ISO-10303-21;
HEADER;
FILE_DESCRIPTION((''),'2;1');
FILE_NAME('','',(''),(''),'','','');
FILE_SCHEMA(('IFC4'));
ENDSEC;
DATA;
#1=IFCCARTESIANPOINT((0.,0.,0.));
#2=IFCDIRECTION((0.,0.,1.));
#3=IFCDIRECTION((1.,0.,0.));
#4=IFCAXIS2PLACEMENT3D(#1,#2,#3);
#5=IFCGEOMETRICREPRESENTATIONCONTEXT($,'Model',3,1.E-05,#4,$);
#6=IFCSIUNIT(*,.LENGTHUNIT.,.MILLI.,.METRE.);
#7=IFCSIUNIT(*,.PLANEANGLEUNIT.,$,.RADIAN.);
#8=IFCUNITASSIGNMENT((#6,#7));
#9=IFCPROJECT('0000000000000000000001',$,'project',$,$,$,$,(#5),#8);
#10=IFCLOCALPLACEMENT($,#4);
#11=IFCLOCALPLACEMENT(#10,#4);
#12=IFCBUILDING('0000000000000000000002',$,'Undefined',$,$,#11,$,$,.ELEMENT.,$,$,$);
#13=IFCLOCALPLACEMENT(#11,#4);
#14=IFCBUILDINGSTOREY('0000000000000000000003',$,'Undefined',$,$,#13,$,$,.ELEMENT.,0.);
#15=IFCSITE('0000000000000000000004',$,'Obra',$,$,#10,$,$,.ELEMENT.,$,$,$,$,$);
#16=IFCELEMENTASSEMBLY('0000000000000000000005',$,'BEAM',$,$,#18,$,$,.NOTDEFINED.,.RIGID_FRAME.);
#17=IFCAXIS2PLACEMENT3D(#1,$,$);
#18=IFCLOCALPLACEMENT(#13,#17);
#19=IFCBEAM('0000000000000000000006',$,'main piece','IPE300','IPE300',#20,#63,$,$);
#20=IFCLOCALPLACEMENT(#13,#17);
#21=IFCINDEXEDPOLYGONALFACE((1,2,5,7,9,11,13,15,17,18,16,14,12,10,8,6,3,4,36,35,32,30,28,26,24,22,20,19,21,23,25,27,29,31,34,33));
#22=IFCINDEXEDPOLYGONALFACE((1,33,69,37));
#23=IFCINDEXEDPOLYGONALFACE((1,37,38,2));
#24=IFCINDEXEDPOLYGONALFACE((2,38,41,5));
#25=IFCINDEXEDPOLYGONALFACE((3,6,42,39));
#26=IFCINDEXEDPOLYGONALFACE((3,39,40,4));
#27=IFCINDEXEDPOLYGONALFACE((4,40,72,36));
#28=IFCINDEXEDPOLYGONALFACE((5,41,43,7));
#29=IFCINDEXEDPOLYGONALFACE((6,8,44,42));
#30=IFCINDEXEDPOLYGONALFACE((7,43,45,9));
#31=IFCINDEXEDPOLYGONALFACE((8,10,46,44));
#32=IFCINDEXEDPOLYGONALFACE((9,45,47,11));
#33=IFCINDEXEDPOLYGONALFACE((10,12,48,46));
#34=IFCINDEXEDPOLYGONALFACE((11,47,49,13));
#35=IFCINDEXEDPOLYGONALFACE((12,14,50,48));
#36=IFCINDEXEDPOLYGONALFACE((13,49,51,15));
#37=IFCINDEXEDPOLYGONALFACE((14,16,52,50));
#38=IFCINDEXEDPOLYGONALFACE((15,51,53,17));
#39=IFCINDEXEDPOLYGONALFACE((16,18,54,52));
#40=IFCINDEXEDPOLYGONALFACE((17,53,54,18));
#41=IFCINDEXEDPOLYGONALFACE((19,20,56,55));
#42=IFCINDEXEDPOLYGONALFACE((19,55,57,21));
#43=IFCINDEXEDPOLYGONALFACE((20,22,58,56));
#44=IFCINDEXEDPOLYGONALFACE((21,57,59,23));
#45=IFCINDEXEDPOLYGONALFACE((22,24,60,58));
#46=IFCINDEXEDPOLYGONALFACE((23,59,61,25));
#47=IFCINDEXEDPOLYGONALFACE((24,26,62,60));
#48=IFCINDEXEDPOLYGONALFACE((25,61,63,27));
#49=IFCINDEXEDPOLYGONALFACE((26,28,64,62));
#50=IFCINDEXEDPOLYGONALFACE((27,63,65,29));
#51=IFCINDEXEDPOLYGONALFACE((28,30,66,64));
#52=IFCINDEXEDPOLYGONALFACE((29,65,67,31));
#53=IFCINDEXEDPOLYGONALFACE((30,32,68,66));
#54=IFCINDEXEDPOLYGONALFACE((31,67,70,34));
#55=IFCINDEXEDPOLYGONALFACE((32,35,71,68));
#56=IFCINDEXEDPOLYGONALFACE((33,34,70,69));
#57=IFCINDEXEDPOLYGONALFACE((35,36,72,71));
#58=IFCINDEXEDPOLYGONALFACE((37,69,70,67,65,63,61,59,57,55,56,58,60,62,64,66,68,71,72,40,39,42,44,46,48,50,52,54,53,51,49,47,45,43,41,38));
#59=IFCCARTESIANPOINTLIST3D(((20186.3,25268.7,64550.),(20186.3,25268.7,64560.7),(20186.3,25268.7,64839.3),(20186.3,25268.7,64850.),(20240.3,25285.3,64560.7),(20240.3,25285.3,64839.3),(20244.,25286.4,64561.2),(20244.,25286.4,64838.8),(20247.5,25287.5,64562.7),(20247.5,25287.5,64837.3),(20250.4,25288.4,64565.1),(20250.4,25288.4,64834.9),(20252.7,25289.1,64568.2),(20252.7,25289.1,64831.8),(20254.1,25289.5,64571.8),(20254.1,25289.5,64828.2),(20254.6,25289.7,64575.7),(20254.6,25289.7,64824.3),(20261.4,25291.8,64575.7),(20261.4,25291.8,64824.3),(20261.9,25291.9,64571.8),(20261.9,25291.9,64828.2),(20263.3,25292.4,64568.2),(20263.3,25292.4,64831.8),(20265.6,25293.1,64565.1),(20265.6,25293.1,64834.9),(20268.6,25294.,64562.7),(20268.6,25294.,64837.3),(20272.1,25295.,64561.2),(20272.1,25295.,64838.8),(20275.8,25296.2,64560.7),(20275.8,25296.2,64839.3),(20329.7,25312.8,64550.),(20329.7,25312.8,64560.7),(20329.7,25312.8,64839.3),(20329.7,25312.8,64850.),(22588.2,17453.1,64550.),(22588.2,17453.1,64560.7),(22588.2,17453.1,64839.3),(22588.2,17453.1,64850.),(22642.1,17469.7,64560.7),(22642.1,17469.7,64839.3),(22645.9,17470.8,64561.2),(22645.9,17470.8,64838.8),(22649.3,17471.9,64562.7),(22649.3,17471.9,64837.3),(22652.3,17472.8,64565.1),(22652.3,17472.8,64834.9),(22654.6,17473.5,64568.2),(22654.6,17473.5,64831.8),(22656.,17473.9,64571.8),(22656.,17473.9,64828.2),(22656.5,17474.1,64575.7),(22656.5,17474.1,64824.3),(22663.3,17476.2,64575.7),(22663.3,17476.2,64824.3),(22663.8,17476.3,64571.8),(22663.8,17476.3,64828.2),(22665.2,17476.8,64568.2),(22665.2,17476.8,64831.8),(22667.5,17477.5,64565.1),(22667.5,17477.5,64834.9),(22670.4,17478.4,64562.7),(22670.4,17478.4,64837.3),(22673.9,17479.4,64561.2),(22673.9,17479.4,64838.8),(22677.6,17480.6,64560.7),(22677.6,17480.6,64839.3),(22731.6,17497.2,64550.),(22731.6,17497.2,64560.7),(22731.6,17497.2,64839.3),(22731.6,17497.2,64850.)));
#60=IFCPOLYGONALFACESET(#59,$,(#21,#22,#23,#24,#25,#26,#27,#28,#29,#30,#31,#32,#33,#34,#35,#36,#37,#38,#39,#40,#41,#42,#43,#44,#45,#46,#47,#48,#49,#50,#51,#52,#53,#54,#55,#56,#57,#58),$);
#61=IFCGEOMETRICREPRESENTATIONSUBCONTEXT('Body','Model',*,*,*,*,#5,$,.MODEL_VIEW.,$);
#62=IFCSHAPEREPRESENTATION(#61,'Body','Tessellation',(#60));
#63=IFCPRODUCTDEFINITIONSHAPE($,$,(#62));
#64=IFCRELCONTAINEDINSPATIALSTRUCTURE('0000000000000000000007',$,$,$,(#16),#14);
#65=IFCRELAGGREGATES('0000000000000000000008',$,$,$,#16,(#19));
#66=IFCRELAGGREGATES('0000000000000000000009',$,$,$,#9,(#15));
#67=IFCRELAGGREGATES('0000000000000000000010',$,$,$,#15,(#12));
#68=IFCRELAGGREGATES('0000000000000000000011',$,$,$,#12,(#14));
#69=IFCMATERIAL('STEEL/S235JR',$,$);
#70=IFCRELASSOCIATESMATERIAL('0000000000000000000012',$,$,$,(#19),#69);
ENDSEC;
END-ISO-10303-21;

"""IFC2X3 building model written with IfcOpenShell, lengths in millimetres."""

from ifc_helpers import new_model, si_unit, frame, origin_with_axes, origin_2d_with_axis, place, context, subcontext, project, spatial, i_section, extrude, material, element, aggregate, save


model = new_model("IFC2X3")

# Units and contexts
model_context = context("Model", 3, precision=1e-05, world=origin_with_axes())
body_context = subcontext(model_context, "Body", "Model", "MODEL_VIEW")
ifc_project = project(units=[si_unit("LENGTHUNIT", "METRE", prefix="MILLI"), si_unit("PLANEANGLEUNIT", "RADIAN")], contexts=[model_context])

# Site, building, storey
site_placement = place(None, origin_with_axes())
site = spatial("IfcSite", under=ifc_project, at=site_placement, Name="Obra", CompositionType="ELEMENT")
building_placement = place(site_placement, origin_with_axes())
building = spatial("IfcBuilding", under=site, at=building_placement, Name="Undefined", CompositionType="ELEMENT")
storey_placement = place(building_placement, origin_with_axes())
storey = spatial("IfcBuildingStorey", under=building, at=storey_placement, Name="Undefined", CompositionType="ELEMENT", Elevation=0.0)

# Shared definitions
ifc_material_1 = material(Name="STEEL/S235JR")

# Element assembly, beam
assembly_1_placement = place(storey_placement, origin_with_axes())
assembly_1 = element("IfcElementAssembly", 1, at=assembly_1_placement, inside=storey, Name="BEAM", AssemblyPlace="NOTDEFINED", PredefinedType="RIGID_FRAME")
beam_1_placement = place(assembly_1_placement, frame((22659.9, 17475.1, 64700.0), z_axis=(0.0, 0.0, 1.0), x_axis=(-0.293756, 0.955881, 0.0)))
beam_1 = element("IfcBeam", 2, at=beam_1_placement, material=ifc_material_1, Name="main piece", Description="IPE300", ObjectType="IPE300", context=body_context, shape_type="SweptSolid", body=[
    extrude(i_section(OverallWidth=150.0, OverallDepth=300.0, WebThickness=7.1, FlangeThickness=10.7, FilletRadius=15.0, at=origin_2d_with_axis()), frame((8176.3, 0.0, 0.0), z_axis=(-1.0, 0.0, 0.0), x_axis=(0.0, -1.0, 0.0)), (0.0, 0.0, 1.0), 8176.3),
])
aggregate(assembly_1, [beam_1])

save(model, "model.ifc")
